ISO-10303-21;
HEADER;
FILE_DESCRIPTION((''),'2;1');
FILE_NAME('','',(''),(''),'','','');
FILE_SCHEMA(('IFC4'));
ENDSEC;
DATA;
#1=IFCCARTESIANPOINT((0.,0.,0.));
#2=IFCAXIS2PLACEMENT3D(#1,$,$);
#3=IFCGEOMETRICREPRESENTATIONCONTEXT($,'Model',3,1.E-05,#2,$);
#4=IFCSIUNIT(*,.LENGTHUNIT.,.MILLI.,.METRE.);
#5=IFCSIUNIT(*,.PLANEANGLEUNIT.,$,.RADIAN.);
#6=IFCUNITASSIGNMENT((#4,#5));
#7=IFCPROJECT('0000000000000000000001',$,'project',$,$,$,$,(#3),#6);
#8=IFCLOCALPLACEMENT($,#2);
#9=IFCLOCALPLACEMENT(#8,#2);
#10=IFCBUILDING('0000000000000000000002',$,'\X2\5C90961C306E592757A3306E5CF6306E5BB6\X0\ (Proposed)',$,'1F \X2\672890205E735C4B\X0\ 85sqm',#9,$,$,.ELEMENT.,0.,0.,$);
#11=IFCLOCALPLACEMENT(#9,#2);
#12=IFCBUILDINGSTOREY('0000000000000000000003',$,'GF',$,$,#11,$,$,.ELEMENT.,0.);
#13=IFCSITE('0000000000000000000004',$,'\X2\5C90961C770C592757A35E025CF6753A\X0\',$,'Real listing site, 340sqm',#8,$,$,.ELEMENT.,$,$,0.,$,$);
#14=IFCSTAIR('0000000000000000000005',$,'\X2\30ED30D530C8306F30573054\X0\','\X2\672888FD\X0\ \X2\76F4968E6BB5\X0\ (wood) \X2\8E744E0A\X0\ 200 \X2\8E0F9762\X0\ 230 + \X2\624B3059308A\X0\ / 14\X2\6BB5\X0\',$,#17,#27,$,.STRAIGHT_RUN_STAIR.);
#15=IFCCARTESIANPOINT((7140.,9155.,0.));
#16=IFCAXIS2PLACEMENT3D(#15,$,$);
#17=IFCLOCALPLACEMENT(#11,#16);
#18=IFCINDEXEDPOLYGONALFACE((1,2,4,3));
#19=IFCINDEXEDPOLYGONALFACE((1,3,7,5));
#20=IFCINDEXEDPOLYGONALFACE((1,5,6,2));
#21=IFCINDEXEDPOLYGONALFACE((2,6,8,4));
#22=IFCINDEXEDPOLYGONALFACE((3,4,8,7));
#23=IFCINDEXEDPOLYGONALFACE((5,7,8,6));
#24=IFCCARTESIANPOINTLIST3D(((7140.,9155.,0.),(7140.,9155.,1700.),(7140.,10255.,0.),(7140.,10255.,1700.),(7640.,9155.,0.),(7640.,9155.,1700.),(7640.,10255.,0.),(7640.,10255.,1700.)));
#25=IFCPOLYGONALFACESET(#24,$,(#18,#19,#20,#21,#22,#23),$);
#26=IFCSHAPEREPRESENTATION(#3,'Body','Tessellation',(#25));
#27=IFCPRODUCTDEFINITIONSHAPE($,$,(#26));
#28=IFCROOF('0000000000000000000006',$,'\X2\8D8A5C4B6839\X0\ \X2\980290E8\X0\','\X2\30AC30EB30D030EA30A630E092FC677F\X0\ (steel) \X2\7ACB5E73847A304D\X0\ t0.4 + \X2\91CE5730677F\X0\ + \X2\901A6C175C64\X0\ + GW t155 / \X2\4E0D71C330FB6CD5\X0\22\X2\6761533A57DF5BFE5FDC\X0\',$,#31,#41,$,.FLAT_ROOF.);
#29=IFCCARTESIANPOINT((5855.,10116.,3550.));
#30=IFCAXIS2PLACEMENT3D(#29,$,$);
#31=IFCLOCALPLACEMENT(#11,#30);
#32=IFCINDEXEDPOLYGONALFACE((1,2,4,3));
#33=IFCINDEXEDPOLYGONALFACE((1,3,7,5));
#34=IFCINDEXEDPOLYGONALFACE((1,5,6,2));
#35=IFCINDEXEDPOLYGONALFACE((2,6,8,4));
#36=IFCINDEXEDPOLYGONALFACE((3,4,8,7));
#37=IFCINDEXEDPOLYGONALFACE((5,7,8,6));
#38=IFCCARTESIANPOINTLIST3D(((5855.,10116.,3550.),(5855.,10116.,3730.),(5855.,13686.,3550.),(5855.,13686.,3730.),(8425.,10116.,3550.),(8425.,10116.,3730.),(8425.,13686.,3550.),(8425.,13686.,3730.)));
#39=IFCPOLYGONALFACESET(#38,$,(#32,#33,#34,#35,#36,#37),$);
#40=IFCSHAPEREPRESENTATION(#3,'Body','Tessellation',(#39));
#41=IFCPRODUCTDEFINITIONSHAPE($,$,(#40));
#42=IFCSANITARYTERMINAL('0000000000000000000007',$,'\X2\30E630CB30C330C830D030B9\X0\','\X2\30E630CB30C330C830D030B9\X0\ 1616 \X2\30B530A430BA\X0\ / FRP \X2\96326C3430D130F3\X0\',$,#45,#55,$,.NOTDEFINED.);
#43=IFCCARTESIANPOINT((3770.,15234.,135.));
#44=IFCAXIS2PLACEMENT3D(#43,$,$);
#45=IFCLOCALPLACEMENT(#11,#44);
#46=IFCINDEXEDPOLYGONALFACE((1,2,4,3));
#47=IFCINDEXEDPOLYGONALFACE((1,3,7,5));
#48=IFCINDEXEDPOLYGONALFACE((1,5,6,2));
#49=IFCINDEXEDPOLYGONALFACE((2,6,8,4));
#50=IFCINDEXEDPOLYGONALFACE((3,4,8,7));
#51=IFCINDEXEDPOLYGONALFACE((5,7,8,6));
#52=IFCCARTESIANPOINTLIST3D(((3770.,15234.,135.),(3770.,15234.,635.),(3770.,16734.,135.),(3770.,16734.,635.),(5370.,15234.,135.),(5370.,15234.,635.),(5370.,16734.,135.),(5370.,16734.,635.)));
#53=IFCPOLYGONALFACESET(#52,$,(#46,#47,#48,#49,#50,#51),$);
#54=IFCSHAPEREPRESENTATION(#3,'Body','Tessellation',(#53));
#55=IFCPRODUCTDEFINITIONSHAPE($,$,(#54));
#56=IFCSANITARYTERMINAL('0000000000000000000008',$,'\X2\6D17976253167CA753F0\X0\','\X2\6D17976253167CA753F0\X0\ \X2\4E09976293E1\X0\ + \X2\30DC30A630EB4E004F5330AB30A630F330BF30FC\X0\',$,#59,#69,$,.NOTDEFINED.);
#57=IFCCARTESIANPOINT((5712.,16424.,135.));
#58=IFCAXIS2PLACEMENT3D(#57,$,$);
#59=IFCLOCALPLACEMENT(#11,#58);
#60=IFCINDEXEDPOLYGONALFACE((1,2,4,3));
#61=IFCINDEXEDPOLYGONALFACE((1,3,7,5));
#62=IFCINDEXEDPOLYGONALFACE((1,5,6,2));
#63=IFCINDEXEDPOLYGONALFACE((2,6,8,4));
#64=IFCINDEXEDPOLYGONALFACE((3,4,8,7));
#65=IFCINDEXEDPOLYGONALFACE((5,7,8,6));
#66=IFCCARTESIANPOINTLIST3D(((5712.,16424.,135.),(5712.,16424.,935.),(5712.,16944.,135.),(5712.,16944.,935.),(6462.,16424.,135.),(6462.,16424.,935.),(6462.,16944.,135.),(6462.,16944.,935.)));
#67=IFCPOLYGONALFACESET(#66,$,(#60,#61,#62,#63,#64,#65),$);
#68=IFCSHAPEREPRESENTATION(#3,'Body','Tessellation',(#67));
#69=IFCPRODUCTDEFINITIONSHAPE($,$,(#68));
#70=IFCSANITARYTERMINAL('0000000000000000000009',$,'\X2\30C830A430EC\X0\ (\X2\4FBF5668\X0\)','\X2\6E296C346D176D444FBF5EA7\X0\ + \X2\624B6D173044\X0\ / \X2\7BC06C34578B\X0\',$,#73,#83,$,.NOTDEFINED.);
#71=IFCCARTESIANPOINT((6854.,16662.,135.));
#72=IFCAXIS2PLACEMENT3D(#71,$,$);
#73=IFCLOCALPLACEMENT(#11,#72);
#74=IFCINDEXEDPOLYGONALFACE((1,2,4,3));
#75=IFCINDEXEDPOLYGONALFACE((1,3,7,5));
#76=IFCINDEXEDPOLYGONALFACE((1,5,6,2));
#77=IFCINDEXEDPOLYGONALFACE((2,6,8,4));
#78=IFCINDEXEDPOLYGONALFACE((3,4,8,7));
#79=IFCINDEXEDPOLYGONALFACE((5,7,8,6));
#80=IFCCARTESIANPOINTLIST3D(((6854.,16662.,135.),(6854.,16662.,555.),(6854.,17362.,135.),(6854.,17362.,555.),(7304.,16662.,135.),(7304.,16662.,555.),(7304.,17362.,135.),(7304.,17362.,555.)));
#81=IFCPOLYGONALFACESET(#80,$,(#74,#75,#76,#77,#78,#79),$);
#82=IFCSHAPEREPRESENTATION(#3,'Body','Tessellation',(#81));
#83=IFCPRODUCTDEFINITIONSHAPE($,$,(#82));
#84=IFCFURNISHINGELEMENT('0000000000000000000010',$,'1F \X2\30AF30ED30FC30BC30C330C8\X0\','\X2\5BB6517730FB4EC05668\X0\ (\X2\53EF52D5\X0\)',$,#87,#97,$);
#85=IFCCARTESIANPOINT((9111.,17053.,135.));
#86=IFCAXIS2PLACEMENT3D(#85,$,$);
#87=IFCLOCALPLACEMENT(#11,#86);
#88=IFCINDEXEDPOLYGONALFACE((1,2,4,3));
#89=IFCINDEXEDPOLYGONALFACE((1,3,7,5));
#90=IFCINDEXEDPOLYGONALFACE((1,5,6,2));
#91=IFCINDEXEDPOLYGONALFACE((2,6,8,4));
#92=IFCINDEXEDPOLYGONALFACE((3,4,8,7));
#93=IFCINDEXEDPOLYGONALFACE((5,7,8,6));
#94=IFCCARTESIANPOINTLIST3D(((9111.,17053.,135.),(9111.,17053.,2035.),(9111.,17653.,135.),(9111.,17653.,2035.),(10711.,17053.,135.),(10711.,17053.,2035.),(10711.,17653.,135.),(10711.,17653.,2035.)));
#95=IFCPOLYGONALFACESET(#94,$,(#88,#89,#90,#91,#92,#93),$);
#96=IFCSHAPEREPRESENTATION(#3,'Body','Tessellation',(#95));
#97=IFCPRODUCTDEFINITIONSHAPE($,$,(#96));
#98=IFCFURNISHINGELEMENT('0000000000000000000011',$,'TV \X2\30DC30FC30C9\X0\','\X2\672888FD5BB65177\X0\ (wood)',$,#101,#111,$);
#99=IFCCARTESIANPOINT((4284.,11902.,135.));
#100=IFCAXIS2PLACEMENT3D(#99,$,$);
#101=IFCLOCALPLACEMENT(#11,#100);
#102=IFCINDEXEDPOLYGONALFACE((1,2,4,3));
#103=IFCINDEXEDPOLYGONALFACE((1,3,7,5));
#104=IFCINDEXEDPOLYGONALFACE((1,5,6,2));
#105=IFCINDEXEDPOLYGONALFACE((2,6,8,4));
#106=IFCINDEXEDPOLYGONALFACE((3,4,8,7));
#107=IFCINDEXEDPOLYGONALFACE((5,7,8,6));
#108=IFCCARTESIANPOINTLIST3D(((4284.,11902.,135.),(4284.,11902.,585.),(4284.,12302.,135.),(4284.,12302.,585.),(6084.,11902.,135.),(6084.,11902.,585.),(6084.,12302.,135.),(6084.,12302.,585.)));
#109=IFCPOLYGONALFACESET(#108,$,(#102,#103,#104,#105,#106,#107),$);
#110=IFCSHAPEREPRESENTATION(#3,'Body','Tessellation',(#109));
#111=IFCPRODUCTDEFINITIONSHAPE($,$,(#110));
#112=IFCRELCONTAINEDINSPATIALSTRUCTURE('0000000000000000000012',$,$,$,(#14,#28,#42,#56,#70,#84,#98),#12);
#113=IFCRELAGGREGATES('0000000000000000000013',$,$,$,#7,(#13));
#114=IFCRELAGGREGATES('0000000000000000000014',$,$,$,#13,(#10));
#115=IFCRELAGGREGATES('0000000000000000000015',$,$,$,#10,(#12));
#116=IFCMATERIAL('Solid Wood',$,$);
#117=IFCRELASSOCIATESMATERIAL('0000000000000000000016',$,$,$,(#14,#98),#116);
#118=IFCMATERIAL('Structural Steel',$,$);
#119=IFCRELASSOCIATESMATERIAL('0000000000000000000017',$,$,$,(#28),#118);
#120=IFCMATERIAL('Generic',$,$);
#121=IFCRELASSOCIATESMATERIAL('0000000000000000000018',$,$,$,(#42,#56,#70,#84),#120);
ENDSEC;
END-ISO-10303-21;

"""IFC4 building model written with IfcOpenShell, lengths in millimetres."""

from ifc_helpers import new_model, si_unit, frame, frame_2d, origin, place, context, project, spatial, rectangle, extrude, material, element, save


model = new_model("IFC4")

# Units and contexts
model_context = context("Model", 3, precision=1e-05, world=origin())
ifc_project = project(units=[si_unit("LENGTHUNIT", "METRE", prefix="MILLI"), si_unit("PLANEANGLEUNIT", "RADIAN")], contexts=[model_context])

# Site, building, storey
site_placement = place(None, origin())
site = spatial("IfcSite", under=ifc_project, at=site_placement, Name="岐阜県大垣市島町", ObjectType="Real listing site, 340sqm", CompositionType="ELEMENT", RefElevation=0.0)
building_placement = place(site_placement, origin())
building = spatial("IfcBuilding", under=site, at=building_placement, Name="岐阜の大垣の島の家 (Proposed)", ObjectType="1F 木造平屋 85sqm", CompositionType="ELEMENT", ElevationOfRefHeight=0.0, ElevationOfTerrain=0.0)
storey_placement = place(building_placement, origin())
storey = spatial("IfcBuildingStorey", under=building, at=storey_placement, Name="GF", CompositionType="ELEMENT", Elevation=0.0)

# Shared definitions
ifc_material_1 = material(Name="Solid Wood")

# Stair
stair_placement = place(storey_placement, frame((7140.0, 9155.0, 0.0)))
element("IfcStair", 1, at=stair_placement, inside=storey, material=ifc_material_1, Name="ロフトはしご", Description="木製 直階段 (wood) 蹴上 200 踏面 230 + 手すり / 14段", PredefinedType="STRAIGHT_RUN_STAIR", context=model_context, shape_type="SweptSolid", body=[
    extrude(rectangle(XDim=500.0, YDim=1100.0, at=frame_2d((250.0, 550.0))), frame((7140.0, 9155.0, 0.0)), (0.0, 0.0, 1.0), 1700.0),
])

# Roof
ifc_material_2 = material(Name="Structural Steel")
roof_placement = place(storey_placement, frame((5855.0, 10116.0, 3550.0)))
element("IfcRoof", 2, at=roof_placement, inside=storey, material=ifc_material_2, Name="越屋根 頂部", Description="ガルバリウム鋼板 (steel) 立平葺き t0.4 + 野地板 + 通気層 + GW t155 / 不燃・法22条区域対応", PredefinedType="FLAT_ROOF", context=model_context, shape_type="SweptSolid", body=[
    extrude(rectangle(XDim=2570.0, YDim=3570.0, at=frame_2d((1285.0, 1785.0))), frame((5855.0, 10116.0, 3550.0)), (0.0, 0.0, 1.0), 180.0),
])

# Sanitary terminals
ifc_material_3 = material(Name="Generic")
sanitary_terminal_1_placement = place(storey_placement, frame((3770.0, 15234.0, 135.0)))
element("IfcSanitaryTerminal", 3, at=sanitary_terminal_1_placement, inside=storey, material=ifc_material_3, Name="ユニットバス", Description="ユニットバス 1616 サイズ / FRP 防水パン", PredefinedType="NOTDEFINED", context=model_context, shape_type="SweptSolid", body=[
    extrude(rectangle(XDim=1600.0, YDim=1500.0, at=frame_2d((800.0, 750.0))), frame((3770.0, 15234.0, 135.0)), (0.0, 0.0, 1.0), 500.0),
])
sanitary_terminal_2_placement = place(storey_placement, frame((5712.0, 16424.0, 135.0)))
element("IfcSanitaryTerminal", 4, at=sanitary_terminal_2_placement, inside=storey, material=ifc_material_3, Name="洗面化粧台", Description="洗面化粧台 三面鏡 + ボウル一体カウンター", PredefinedType="NOTDEFINED", context=model_context, shape_type="SweptSolid", body=[
    extrude(rectangle(XDim=750.0, YDim=520.0, at=frame_2d((375.0, 260.0))), frame((5712.0, 16424.0, 135.0)), (0.0, 0.0, 1.0), 800.0),
])
sanitary_terminal_3_placement = place(storey_placement, frame((6854.0, 16662.0, 135.0)))
element("IfcSanitaryTerminal", 5, at=sanitary_terminal_3_placement, inside=storey, material=ifc_material_3, Name="トイレ (便器)", Description="温水洗浄便座 + 手洗い / 節水型", PredefinedType="NOTDEFINED", context=model_context, shape_type="SweptSolid", body=[
    extrude(rectangle(XDim=450.0, YDim=700.0, at=frame_2d((225.0, 350.0))), frame((6854.0, 16662.0, 135.0)), (0.0, 0.0, 1.0), 420.0),
])

# Furnishing elements
furnishing_1_placement = place(storey_placement, frame((9111.0, 17053.0, 135.0)))
element("IfcFurnishingElement", 6, at=furnishing_1_placement, inside=storey, material=ifc_material_3, Name="1F クローゼット", Description="家具・什器 (可動)", context=model_context, shape_type="SweptSolid", body=[
    extrude(rectangle(XDim=1600.0, YDim=600.0, at=frame_2d((800.0, 300.0))), frame((9111.0, 17053.0, 135.0)), (0.0, 0.0, 1.0), 1900.0),
])
furnishing_2_placement = place(storey_placement, frame((4284.0, 11902.0, 135.0)))
element("IfcFurnishingElement", 7, at=furnishing_2_placement, inside=storey, material=ifc_material_1, Name="TV ボード", Description="木製家具 (wood)", context=model_context, shape_type="SweptSolid", body=[
    extrude(rectangle(XDim=1800.0, YDim=400.0, at=frame_2d((900.0, 200.0))), frame((4284.0, 11902.0, 135.0)), (0.0, 0.0, 1.0), 450.0),
])

save(model, "model.ifc")
